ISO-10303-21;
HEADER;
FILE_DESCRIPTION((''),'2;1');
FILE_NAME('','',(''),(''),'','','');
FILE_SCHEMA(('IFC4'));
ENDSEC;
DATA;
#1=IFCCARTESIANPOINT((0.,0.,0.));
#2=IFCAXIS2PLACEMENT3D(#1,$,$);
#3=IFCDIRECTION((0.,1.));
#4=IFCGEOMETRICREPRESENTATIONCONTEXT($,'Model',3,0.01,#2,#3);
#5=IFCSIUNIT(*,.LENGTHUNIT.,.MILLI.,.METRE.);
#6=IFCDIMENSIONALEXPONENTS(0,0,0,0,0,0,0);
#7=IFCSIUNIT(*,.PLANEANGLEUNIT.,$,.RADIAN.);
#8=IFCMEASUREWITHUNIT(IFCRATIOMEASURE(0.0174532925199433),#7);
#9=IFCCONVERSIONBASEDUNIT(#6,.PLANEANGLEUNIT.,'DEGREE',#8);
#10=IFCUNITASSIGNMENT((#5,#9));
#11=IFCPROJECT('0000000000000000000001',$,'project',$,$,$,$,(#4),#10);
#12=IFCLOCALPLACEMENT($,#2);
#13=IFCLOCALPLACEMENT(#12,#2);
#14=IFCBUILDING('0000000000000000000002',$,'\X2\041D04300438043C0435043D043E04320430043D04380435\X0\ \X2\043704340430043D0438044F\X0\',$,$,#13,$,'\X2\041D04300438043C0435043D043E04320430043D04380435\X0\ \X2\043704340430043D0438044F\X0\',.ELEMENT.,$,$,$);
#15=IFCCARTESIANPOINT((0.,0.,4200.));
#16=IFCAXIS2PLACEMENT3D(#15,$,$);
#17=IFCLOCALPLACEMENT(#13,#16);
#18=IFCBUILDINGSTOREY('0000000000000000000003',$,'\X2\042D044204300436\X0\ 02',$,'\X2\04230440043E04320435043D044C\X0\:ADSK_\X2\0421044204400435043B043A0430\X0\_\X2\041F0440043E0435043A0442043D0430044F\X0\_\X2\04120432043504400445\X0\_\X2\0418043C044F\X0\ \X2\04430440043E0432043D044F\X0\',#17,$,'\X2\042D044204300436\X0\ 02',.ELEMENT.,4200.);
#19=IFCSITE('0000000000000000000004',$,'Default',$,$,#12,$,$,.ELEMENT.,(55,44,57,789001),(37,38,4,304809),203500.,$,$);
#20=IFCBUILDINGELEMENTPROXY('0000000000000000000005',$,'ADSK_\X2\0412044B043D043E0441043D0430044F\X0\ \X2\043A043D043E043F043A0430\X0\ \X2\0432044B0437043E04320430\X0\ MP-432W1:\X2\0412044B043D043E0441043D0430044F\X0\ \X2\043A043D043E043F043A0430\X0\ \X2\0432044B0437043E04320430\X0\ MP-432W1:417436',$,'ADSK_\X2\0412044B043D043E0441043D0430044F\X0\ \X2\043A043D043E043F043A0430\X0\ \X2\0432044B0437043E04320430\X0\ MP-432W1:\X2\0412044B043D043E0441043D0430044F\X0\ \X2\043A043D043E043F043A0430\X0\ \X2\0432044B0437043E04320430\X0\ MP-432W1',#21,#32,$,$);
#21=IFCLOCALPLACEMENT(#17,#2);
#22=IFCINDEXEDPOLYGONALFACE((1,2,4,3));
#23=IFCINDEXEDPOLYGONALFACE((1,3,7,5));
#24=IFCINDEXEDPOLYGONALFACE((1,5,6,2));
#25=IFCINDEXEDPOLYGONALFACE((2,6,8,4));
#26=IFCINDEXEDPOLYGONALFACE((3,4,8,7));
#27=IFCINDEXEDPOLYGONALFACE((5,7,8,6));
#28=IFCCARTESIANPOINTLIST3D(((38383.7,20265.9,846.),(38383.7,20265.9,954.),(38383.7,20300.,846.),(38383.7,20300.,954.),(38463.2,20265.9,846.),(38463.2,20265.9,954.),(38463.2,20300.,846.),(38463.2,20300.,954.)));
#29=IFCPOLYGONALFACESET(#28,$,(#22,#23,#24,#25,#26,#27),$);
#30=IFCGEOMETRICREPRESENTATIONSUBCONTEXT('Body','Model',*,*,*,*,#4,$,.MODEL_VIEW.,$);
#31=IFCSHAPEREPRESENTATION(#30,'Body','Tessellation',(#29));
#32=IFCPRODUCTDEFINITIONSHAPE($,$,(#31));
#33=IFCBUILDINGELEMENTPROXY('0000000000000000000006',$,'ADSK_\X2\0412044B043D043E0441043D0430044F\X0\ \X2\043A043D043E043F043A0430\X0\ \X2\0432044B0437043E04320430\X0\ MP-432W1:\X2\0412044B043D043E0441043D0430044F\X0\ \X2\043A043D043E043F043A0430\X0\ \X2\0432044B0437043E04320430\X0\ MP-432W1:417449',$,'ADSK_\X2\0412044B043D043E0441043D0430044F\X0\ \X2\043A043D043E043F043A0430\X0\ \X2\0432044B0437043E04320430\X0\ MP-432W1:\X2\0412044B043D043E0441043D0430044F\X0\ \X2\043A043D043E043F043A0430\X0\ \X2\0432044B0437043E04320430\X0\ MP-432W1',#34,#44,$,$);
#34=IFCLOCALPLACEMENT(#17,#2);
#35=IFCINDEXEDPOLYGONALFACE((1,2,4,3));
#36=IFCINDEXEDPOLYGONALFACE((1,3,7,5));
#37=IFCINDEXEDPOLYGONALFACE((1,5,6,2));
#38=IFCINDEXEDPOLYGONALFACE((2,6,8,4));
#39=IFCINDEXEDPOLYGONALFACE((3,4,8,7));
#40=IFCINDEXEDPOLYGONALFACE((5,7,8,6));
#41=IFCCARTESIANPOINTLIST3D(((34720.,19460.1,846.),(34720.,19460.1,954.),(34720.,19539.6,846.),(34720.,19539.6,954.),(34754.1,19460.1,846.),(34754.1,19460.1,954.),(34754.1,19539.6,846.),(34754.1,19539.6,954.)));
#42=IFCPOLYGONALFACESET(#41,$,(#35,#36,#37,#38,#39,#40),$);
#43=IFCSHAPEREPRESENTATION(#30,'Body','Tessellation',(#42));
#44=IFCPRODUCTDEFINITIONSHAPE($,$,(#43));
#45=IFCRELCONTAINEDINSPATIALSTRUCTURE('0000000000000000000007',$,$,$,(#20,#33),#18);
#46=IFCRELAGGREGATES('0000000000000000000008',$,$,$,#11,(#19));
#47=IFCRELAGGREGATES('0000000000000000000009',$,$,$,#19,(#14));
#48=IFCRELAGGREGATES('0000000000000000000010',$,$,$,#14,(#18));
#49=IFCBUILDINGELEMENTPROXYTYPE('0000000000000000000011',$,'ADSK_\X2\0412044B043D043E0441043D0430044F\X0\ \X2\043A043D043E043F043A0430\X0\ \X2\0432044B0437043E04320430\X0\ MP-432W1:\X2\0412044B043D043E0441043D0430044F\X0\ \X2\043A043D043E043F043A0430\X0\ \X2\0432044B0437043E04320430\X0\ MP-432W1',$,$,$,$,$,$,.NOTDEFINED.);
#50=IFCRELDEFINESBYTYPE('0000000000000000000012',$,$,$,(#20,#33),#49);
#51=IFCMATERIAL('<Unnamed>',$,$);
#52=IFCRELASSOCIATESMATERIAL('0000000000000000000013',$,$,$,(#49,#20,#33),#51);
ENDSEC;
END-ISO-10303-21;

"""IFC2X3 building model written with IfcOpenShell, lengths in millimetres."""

from ifc_helpers import new_model, entity, si_unit, converted_unit, direction, frame, origin, origin_2d_with_axis, place, context, subcontext, project, spatial, rectangle, extrude, source, transform, mapped, material, type_object, type_shapes, element, save


model = new_model("IFC2X3")

# Units and contexts
model_context = context("Model", 3, precision=0.01, world=origin(), true_north=direction((0.0, 1.0)))
body_context = subcontext(model_context, "Body", "Model", "MODEL_VIEW")
ifc_project = project(units=[si_unit("LENGTHUNIT", "METRE", prefix="MILLI"), converted_unit("PLANEANGLEUNIT", "DEGREE", entity("IfcRatioMeasure", 0.0174532925199433), si_unit("PLANEANGLEUNIT", "RADIAN"), dimensions=[0, 0, 0, 0, 0, 0, 0])], contexts=[model_context])

# Site, building, storey
site_placement = place(None, origin())
site = spatial("IfcSite", under=ifc_project, at=site_placement, Name="Default", CompositionType="ELEMENT", RefLatitude=(55, 44, 57, 789001), RefLongitude=(37, 38, 4, 304809), RefElevation=203500.0)
building_placement = place(site_placement, origin())
building = spatial("IfcBuilding", under=site, at=building_placement, Name="Наименование здания", LongName="Наименование здания", CompositionType="ELEMENT")
storey_placement = place(building_placement, frame((0.0, 0.0, 4200.0)))
storey = spatial("IfcBuildingStorey", under=building, at=storey_placement, Name="Этаж 02", ObjectType="Уровень:ADSK_Стрелка_Проектная_Вверх_Имя уровня", LongName="Этаж 02", CompositionType="ELEMENT", Elevation=4200.0)

# Building element proxies
ifc_material_1 = material(Name="<Unnamed>")
building_element_proxy_type_1 = type_object("IfcBuildingElementProxyType", Name="ADSK_Выносная кнопка вызова MP-432W1:Выносная кнопка вызова MP-432W1", PredefinedType="NOTDEFINED", material=ifc_material_1)
shared_shape_1 = source(origin(), body_context, "Body", "SweptSolid", [
    extrude(rectangle(XDim=79.5, YDim=34.1, at=origin_2d_with_axis()), frame((0.0, 15.0, -54.0), z_axis=(0.0, 0.0, 1.0), x_axis=(-1.0, 0.0, 0.0)), (0.0, 0.0, 1.0), 108.0),
])
type_shapes(building_element_proxy_type_1, [shared_shape_1])
for number, where, name in (
    (1, (38423.5, 20268.0, 900.0), "ADSK_Выносная кнопка вызова MP-432W1:Выносная кнопка вызова MP-432W1:417436"),
):
    element("IfcBuildingElementProxy", number, at=place(storey_placement, frame(where)), inside=storey, type_object=building_element_proxy_type_1, material=ifc_material_1, Name=name, ObjectType="ADSK_Выносная кнопка вызова MP-432W1:Выносная кнопка вызова MP-432W1", context=body_context, shape_type="MappedRepresentation", body=[
        mapped(shared_shape_1, transform((0.0, 0.0, 0.0), scale=1.0)),
    ])
proxy_1_placement = place(storey_placement, frame((34752.0, 19499.9, 900.0), z_axis=(0.0, 0.0, 1.0), x_axis=(0.0, 1.0, 0.0)))
element("IfcBuildingElementProxy", 2, at=proxy_1_placement, inside=storey, type_object=building_element_proxy_type_1, material=ifc_material_1, Name="ADSK_Выносная кнопка вызова MP-432W1:Выносная кнопка вызова MP-432W1:417449", ObjectType="ADSK_Выносная кнопка вызова MP-432W1:Выносная кнопка вызова MP-432W1", context=body_context, shape_type="MappedRepresentation", body=[
    mapped(shared_shape_1, transform((0.0, 0.0, 0.0), scale=1.0)),
])

save(model, "model.ifc")
